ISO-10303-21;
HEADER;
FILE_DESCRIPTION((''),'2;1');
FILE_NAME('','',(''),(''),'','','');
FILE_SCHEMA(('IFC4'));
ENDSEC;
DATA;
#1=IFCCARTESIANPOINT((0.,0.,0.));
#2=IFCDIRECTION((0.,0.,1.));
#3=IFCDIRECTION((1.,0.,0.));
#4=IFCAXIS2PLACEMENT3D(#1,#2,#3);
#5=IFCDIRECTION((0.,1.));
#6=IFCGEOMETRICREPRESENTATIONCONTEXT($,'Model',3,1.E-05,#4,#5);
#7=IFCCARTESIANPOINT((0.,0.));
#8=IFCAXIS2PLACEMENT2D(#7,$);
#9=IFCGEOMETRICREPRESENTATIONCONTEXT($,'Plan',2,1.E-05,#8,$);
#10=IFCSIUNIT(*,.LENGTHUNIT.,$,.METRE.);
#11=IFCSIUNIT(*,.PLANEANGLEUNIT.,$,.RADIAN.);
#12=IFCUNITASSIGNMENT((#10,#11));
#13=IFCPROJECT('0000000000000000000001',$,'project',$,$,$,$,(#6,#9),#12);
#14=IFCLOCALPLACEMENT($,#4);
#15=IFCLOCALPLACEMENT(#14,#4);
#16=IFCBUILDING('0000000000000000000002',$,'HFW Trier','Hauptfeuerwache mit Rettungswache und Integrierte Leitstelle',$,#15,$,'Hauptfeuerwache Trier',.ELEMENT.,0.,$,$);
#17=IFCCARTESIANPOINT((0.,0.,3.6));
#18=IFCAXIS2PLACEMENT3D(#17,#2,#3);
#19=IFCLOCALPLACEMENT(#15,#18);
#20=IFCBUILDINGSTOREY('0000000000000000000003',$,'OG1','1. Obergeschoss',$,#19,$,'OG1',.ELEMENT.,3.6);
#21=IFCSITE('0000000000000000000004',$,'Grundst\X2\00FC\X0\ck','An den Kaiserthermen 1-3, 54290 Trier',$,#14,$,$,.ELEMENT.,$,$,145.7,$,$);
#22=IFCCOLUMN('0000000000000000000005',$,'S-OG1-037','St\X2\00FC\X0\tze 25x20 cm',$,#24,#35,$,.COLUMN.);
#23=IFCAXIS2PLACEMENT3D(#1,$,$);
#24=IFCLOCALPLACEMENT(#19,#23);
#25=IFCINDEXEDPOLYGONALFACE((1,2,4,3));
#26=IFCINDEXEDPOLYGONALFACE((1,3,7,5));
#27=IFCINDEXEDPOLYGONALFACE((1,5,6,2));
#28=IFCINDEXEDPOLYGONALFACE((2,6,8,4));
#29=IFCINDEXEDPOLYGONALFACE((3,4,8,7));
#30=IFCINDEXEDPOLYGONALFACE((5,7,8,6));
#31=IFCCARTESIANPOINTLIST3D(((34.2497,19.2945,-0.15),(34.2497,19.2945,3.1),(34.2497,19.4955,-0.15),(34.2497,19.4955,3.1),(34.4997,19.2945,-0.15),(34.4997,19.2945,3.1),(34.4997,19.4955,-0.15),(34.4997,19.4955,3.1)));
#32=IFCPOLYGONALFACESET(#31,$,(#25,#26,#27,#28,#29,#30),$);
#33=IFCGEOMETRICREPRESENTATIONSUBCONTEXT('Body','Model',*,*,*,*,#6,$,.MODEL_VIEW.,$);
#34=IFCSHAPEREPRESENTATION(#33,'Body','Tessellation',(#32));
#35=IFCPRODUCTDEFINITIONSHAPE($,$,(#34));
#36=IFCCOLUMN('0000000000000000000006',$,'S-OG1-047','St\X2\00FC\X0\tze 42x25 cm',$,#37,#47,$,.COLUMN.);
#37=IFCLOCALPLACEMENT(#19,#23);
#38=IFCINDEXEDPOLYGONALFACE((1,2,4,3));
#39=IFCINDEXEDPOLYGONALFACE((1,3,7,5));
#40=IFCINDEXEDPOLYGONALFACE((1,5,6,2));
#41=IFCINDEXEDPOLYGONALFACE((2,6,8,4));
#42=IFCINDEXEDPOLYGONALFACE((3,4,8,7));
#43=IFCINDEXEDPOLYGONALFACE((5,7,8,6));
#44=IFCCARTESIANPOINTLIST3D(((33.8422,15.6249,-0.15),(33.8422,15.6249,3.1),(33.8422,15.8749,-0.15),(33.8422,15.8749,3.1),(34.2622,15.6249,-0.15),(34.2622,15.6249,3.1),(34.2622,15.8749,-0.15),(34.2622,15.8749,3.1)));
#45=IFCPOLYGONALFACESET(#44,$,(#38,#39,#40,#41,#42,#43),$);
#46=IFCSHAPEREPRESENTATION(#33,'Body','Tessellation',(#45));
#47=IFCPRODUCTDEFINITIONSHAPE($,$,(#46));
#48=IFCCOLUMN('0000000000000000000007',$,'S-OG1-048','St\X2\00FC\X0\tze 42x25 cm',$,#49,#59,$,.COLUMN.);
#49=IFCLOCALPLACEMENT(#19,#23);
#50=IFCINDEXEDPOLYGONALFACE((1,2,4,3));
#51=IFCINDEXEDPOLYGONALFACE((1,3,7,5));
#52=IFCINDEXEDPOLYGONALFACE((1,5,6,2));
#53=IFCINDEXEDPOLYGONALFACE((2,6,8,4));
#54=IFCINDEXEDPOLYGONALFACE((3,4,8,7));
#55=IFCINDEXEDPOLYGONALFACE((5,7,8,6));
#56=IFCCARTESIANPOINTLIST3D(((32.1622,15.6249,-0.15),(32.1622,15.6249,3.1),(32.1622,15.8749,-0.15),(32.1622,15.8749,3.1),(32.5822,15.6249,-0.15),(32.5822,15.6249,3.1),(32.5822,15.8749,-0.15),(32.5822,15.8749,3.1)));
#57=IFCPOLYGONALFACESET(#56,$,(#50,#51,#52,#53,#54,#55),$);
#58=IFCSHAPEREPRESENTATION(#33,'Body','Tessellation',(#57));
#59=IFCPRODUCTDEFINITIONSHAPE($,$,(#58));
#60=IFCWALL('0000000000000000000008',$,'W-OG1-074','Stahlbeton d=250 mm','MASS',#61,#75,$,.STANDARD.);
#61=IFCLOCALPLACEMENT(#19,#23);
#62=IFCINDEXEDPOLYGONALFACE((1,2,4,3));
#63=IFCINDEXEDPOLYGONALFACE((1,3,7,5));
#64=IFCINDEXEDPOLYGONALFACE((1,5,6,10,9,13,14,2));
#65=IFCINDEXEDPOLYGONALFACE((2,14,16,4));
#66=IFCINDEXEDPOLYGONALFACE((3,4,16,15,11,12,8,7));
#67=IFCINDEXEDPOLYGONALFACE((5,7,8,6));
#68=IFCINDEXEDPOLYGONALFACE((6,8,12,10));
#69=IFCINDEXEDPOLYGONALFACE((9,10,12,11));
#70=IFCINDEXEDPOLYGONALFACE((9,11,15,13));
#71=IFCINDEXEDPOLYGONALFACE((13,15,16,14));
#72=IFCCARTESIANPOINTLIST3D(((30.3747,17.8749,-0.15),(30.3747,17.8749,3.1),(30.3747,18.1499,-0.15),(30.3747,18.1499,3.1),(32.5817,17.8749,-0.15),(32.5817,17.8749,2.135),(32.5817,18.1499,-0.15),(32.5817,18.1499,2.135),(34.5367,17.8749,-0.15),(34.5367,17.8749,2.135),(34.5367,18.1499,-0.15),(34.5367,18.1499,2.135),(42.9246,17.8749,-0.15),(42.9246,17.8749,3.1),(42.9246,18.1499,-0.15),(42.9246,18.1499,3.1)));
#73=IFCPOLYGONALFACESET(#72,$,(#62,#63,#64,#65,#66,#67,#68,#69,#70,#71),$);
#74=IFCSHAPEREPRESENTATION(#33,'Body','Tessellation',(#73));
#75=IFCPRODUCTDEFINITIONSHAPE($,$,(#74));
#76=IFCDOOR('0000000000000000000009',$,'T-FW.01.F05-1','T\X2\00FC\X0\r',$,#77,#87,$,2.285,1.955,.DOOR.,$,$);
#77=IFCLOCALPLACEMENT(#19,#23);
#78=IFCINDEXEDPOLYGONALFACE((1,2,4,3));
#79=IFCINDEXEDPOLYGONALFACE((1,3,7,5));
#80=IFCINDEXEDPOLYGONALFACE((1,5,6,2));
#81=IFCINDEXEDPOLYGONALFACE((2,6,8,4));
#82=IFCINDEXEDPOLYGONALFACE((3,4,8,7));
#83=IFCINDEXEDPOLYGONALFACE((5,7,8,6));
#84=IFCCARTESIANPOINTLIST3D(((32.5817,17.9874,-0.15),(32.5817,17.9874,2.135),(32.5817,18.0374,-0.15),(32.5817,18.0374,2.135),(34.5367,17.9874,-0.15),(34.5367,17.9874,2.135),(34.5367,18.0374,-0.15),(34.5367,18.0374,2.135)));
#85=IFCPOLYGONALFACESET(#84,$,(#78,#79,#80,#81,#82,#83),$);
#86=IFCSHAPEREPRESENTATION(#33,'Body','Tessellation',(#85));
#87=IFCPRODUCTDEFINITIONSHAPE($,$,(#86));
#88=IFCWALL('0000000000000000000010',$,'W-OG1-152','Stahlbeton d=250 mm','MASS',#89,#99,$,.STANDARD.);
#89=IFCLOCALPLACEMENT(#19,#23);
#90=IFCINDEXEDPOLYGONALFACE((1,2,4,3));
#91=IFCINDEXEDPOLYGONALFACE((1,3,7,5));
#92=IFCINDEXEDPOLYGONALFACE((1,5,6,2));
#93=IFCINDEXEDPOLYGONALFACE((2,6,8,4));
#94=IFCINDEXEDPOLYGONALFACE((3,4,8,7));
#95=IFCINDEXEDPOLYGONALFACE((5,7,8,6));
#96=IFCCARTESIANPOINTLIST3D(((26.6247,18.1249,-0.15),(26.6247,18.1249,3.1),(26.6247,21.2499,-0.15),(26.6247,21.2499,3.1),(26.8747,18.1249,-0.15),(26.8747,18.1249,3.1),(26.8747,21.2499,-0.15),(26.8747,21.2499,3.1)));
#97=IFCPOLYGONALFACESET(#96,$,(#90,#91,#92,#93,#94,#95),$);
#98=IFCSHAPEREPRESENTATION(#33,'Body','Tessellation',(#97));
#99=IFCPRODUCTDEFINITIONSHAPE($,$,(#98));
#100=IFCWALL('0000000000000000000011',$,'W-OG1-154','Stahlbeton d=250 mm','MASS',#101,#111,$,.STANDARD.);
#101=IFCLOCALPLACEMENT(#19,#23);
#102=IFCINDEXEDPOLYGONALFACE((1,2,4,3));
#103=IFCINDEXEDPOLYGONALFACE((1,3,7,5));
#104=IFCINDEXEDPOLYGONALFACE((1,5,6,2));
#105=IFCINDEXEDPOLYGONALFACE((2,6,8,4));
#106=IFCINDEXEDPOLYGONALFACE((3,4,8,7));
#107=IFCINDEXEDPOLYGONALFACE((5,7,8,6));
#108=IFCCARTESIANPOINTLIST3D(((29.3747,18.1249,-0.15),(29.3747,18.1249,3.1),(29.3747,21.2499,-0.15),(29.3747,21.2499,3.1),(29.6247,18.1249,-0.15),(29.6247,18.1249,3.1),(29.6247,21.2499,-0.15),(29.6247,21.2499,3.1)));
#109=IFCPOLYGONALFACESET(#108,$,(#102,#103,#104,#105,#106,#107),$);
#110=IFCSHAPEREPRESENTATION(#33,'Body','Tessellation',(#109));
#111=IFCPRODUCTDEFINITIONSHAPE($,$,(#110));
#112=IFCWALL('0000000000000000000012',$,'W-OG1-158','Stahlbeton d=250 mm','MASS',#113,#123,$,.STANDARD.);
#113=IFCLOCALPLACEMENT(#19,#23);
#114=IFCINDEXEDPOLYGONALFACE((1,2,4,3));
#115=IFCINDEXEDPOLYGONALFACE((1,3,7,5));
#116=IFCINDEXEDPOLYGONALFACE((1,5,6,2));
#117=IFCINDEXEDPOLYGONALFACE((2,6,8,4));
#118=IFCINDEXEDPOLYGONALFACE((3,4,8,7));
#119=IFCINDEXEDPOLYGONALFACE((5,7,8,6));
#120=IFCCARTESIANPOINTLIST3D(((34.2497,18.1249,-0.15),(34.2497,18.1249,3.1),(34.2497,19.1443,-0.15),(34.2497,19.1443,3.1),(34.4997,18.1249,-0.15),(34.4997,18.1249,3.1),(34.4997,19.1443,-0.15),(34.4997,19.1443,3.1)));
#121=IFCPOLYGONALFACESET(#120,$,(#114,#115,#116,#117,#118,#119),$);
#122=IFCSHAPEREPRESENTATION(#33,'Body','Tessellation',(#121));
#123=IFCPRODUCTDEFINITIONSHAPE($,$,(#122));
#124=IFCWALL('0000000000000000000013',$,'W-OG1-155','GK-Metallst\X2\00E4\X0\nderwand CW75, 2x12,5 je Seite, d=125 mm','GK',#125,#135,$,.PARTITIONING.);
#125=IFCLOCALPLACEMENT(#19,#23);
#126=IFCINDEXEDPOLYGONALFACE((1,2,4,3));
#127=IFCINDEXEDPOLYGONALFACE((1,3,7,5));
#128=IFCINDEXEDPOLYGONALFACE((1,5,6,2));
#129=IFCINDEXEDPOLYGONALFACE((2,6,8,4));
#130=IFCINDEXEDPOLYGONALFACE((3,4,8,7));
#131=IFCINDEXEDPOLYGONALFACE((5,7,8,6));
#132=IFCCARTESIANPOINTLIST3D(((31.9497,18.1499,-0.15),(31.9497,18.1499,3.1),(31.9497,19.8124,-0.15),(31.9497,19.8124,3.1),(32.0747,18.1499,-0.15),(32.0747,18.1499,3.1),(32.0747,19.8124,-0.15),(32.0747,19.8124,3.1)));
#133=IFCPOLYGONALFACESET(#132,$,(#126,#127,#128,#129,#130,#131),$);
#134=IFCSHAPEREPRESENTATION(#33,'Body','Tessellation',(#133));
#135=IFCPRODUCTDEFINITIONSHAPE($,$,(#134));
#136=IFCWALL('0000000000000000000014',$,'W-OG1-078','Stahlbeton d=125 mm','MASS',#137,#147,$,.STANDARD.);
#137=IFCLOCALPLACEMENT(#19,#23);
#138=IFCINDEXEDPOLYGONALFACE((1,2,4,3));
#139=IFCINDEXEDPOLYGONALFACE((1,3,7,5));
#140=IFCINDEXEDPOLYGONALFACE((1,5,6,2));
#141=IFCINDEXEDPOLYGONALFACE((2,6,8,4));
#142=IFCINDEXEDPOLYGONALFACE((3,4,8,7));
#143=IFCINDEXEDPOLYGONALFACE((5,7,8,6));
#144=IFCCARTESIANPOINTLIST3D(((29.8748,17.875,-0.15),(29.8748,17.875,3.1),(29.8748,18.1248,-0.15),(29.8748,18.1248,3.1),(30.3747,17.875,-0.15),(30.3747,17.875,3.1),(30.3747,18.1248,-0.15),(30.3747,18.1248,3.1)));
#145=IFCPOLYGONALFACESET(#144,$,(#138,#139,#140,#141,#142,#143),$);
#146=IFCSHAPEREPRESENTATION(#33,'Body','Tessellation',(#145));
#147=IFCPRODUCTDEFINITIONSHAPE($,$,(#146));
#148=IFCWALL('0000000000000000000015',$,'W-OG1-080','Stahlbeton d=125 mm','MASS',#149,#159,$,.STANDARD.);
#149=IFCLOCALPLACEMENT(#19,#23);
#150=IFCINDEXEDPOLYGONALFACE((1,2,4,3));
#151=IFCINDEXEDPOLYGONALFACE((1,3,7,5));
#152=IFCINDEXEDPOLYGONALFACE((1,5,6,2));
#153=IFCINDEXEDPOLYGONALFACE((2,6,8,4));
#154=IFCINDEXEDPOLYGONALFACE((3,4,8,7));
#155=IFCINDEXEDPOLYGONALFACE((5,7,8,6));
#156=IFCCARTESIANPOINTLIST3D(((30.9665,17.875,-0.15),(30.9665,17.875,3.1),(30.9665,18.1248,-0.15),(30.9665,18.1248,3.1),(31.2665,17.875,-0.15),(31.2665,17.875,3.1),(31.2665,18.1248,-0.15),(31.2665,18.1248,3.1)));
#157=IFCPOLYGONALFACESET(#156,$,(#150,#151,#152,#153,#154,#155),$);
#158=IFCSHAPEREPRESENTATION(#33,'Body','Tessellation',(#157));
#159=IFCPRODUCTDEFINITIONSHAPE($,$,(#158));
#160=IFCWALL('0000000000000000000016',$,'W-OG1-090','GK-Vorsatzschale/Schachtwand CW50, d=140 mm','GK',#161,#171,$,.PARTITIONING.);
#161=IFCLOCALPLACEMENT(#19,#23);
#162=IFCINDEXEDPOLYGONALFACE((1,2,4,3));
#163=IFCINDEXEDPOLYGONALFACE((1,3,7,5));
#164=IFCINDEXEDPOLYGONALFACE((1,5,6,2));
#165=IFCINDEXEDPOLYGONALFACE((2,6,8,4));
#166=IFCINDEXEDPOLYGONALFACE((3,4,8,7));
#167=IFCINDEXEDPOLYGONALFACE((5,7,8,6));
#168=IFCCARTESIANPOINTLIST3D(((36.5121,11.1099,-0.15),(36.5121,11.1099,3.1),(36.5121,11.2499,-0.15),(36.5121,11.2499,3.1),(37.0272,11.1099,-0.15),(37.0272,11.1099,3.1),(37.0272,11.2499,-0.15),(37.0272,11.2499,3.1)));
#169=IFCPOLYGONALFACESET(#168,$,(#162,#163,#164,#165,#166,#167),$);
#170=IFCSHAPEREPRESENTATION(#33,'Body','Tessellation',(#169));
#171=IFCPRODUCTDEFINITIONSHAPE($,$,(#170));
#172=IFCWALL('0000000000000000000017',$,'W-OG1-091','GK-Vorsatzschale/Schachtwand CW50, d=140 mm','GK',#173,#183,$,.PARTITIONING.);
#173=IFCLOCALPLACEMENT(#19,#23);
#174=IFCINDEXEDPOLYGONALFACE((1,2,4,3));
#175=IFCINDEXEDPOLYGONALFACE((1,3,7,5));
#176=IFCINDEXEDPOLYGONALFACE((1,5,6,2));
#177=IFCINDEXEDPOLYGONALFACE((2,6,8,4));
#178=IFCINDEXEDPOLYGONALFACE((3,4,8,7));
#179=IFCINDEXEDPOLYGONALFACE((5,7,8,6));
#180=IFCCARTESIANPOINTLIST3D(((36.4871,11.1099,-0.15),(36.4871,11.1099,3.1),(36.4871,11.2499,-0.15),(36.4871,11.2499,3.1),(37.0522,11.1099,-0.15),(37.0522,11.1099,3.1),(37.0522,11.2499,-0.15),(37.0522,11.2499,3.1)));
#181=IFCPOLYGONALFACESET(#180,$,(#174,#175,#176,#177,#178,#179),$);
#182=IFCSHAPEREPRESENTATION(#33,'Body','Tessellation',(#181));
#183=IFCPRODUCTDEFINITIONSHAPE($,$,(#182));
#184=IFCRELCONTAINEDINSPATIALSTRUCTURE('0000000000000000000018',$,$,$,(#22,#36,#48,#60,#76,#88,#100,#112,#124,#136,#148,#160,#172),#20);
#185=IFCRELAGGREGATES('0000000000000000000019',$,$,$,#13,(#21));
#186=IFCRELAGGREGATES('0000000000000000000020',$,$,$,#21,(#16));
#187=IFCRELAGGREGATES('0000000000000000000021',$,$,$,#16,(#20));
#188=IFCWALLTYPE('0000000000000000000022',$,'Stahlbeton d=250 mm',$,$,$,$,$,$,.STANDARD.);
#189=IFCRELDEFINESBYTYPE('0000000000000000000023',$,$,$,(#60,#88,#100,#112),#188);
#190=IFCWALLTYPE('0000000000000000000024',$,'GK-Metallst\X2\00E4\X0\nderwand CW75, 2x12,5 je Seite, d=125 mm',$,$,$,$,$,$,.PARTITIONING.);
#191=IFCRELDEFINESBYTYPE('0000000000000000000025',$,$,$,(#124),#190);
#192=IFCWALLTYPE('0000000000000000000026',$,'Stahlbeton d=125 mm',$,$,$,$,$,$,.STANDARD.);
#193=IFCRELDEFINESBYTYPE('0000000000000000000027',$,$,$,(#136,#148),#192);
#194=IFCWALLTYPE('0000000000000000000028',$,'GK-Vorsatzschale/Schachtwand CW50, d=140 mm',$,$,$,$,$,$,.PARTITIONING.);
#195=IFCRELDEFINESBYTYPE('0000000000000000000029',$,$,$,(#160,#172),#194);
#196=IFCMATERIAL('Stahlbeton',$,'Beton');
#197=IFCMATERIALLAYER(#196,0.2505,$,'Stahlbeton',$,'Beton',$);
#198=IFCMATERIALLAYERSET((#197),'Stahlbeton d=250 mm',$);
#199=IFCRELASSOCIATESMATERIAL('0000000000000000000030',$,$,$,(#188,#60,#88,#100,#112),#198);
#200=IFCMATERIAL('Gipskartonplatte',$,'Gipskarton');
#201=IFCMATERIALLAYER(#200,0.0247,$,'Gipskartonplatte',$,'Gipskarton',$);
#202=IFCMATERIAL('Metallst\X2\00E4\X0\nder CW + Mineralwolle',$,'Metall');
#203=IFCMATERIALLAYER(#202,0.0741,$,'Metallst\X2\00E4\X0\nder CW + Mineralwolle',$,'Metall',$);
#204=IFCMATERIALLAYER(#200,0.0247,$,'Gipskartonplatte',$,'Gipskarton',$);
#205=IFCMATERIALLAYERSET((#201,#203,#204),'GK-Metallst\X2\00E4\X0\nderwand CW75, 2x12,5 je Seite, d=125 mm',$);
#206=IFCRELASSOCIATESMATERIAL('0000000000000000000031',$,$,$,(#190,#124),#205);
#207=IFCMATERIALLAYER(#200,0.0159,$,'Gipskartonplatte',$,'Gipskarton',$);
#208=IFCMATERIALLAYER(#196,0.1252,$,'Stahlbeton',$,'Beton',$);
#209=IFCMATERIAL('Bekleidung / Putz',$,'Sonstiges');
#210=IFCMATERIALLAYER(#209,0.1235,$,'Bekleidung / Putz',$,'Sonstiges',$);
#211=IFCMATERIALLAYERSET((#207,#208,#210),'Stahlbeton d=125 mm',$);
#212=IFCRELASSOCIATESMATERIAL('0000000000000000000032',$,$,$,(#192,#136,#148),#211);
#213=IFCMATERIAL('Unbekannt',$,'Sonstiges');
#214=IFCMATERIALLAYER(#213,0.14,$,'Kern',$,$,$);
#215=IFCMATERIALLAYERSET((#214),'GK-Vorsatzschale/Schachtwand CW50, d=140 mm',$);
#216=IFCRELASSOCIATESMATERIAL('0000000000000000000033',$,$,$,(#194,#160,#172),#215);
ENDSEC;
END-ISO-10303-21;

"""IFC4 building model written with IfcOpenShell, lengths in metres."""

from ifc_helpers import new_model, si_unit, direction, frame, frame_2d, origin_with_axes, origin_2d, place, context, subcontext, project, spatial, rectangle, extrude, material, layer, layer_set, layer_usage, type_object, element, fill, save


model = new_model("IFC4")

# Units and contexts
model_context = context("Model", 3, precision=1e-05, world=origin_with_axes(), true_north=direction((0.0, 1.0)))
plan_context = context("Plan", 2, precision=1e-05, world=origin_2d())
body_context = subcontext(model_context, "Body", "Model", "MODEL_VIEW")
ifc_project = project(units=[si_unit("LENGTHUNIT", "METRE"), si_unit("PLANEANGLEUNIT", "RADIAN")], contexts=[model_context, plan_context])

# Site, building, storey
site_placement = place(None, origin_with_axes())
site = spatial("IfcSite", under=ifc_project, at=site_placement, Name="Grundstück", Description="An den Kaiserthermen 1-3, 54290 Trier", CompositionType="ELEMENT", RefElevation=145.7)
building_placement = place(site_placement, origin_with_axes())
building = spatial("IfcBuilding", under=site, at=building_placement, Name="HFW Trier", Description="Hauptfeuerwache mit Rettungswache und Integrierte Leitstelle", LongName="Hauptfeuerwache Trier", CompositionType="ELEMENT", ElevationOfRefHeight=0.0)
storey_placement = place(building_placement, frame((0.0, 0.0, 3.6), z_axis=(0.0, 0.0, 1.0), x_axis=(1.0, 0.0, 0.0)))
storey = spatial("IfcBuildingStorey", under=building, at=storey_placement, Name="OG1", Description="1. Obergeschoss", LongName="OG1", CompositionType="ELEMENT", Elevation=3.6)

# Columns
column_placement = place(storey_placement, frame((34.2497, 19.395, -0.15), z_axis=(0.0, 0.0, 1.0), x_axis=(1.0, 0.0, 0.0)))
element("IfcColumn", 1, at=column_placement, inside=storey, Name="S-OG1-037", Description="Stütze 25x20 cm", PredefinedType="COLUMN", context=body_context, shape_type="SweptSolid", body=[
    extrude(rectangle(XDim=0.25, YDim=0.201, at=frame_2d((0.125, 0.0))), origin_with_axes(), (0.0, 0.0, 1.0), 3.25),
])
for number, where, z_axis, x_axis, name in (
    (2, (33.8422, 15.7499, -0.15), (0.0, 0.0, 1.0), (1.0, 0.0, 0.0), "S-OG1-047"),
    (3, (32.1622, 15.7499, -0.15), (0.0, 0.0, 1.0), (1.0, 0.0, 0.0), "S-OG1-048"),
):
    element("IfcColumn", number, at=place(storey_placement, frame(where, z_axis=z_axis, x_axis=x_axis)), inside=storey, Name=name, Description="Stütze 42x25 cm", PredefinedType="COLUMN", context=body_context, shape_type="SweptSolid", body=[
        extrude(rectangle(XDim=0.42, YDim=0.25, at=frame_2d((0.21, 0.0))), origin_with_axes(), (0.0, 0.0, 1.0), 3.25),
    ])

# Wall, opening, door
ifc_material_1 = material(Name="Stahlbeton", Category="Beton")
ifc_layer_1 = layer(ifc_material_1, 0.2505, Name="Stahlbeton", Category="Beton")
ifc_layer_set_1 = layer_set([ifc_layer_1], Name="Stahlbeton d=250 mm")
ifc_layer_usage_1 = layer_usage(ifc_layer_set_1, "AXIS2", "POSITIVE", -0.1375)
wall_type_1 = type_object("IfcWallType", Name="Stahlbeton d=250 mm", PredefinedType="STANDARD", material=ifc_layer_set_1)
wall_1_placement = place(storey_placement, frame((30.3747, 18.0124, -0.15), z_axis=(0.0, 0.0, 1.0), x_axis=(1.0, 0.0, 0.0)))
wall_1 = element("IfcWall", 4, at=wall_1_placement, inside=storey, type_object=wall_type_1, material=ifc_layer_usage_1, Name="W-OG1-074", Description="Stahlbeton d=250 mm", ObjectType="MASS", PredefinedType="STANDARD", context=body_context, shape_type="SweptSolid", body=[
    extrude(rectangle(XDim=12.5499, YDim=0.275, at=frame_2d((6.2749, 0.0))), origin_with_axes(), (0.0, 0.0, 1.0), 3.25),
])
opening_1_placement = place(wall_1_placement, frame((2.207, 0.0, 0.0), z_axis=(0.0, 0.0, 1.0), x_axis=(1.0, 0.0, 0.0)))
opening_1 = element("IfcOpeningElement", 5, at=opening_1_placement, cuts=wall_1, PredefinedType="OPENING", context=body_context, shape_type="SweptSolid", body=[
    extrude(rectangle(XDim=1.955, YDim=0.375, at=frame_2d((0.9775, 0.0))), origin_with_axes(), (0.0, 0.0, 1.0), 2.285),
])
door_1_placement = place(wall_1_placement, frame((2.207, 0.0, 0.0), z_axis=(0.0, 0.0, 1.0), x_axis=(1.0, 0.0, 0.0)))
door_1 = element("IfcDoor", 6, at=door_1_placement, inside=storey, Name="T-FW.01.F05-1", Description="Tür", OverallHeight=2.285, OverallWidth=1.955, PredefinedType="DOOR", context=body_context, shape_type="SweptSolid", body=[
    extrude(rectangle(XDim=1.955, YDim=0.05, at=frame_2d((0.9775, 0.0))), origin_with_axes(), (0.0, 0.0, 1.0), 2.285),
])
fill(opening_1, door_1)

# Walls
ifc_layer_usage_2 = layer_usage(ifc_layer_set_1, "AXIS2", "POSITIVE", -0.125)
wall_2_placement = place(storey_placement, frame((26.7497, 21.2499, -0.15), z_axis=(0.0, 0.0, 1.0), x_axis=(0.0, -1.0, 0.0)))
element("IfcWall", 7, at=wall_2_placement, inside=storey, type_object=wall_type_1, material=ifc_layer_usage_2, Name="W-OG1-152", Description="Stahlbeton d=250 mm", ObjectType="MASS", PredefinedType="STANDARD", context=body_context, shape_type="SweptSolid", body=[
    extrude(rectangle(XDim=3.125, YDim=0.25, at=frame_2d((1.5625, 0.0))), origin_with_axes(), (0.0, 0.0, 1.0), 3.25),
])
ifc_layer_usage_3 = layer_usage(ifc_layer_set_1, "AXIS2", "POSITIVE", -0.125)
wall_3_placement = place(storey_placement, frame((29.4997, 21.2499, -0.15), z_axis=(0.0, 0.0, 1.0), x_axis=(0.0, -1.0, 0.0)))
element("IfcWall", 8, at=wall_3_placement, inside=storey, type_object=wall_type_1, material=ifc_layer_usage_3, Name="W-OG1-154", Description="Stahlbeton d=250 mm", ObjectType="MASS", PredefinedType="STANDARD", context=body_context, shape_type="SweptSolid", body=[
    extrude(rectangle(XDim=3.125, YDim=0.25, at=frame_2d((1.5625, 0.0))), origin_with_axes(), (0.0, 0.0, 1.0), 3.25),
])
ifc_layer_usage_4 = layer_usage(ifc_layer_set_1, "AXIS2", "POSITIVE", -0.125)
wall_4_placement = place(storey_placement, frame((34.3747, 19.1443, -0.15), z_axis=(0.0, 0.0, 1.0), x_axis=(0.0, -1.0, 0.0)))
element("IfcWall", 9, at=wall_4_placement, inside=storey, type_object=wall_type_1, material=ifc_layer_usage_4, Name="W-OG1-158", Description="Stahlbeton d=250 mm", ObjectType="MASS", PredefinedType="STANDARD", context=body_context, shape_type="SweptSolid", body=[
    extrude(rectangle(XDim=1.0194, YDim=0.25, at=frame_2d((0.5097, 0.0))), origin_with_axes(), (0.0, 0.0, 1.0), 3.25),
])
ifc_material_2 = material(Name="Gipskartonplatte", Category="Gipskarton")
ifc_layer_2 = layer(ifc_material_2, 0.0247, Name="Gipskartonplatte", Category="Gipskarton")
ifc_material_3 = material(Name="Metallständer CW + Mineralwolle", Category="Metall")
ifc_layer_3 = layer(ifc_material_3, 0.0741, Name="Metallständer CW + Mineralwolle", Category="Metall")
ifc_layer_4 = layer(ifc_material_2, 0.0247, Name="Gipskartonplatte", Category="Gipskarton")
ifc_layer_set_2 = layer_set([ifc_layer_2, ifc_layer_3, ifc_layer_4], Name="GK-Metallständerwand CW75, 2x12,5 je Seite, d=125 mm")
ifc_layer_usage_5 = layer_usage(ifc_layer_set_2, "AXIS2", "POSITIVE", -0.0625)
wall_type_2 = type_object("IfcWallType", Name="GK-Metallständerwand CW75, 2x12,5 je Seite, d=125 mm", PredefinedType="PARTITIONING", material=ifc_layer_set_2)
wall_5_placement = place(storey_placement, frame((32.0122, 19.8124, -0.15), z_axis=(0.0, 0.0, 1.0), x_axis=(0.0, -1.0, 0.0)))
element("IfcWall", 10, at=wall_5_placement, inside=storey, type_object=wall_type_2, material=ifc_layer_usage_5, Name="W-OG1-155", Description="GK-Metallständerwand CW75, 2x12,5 je Seite, d=125 mm", ObjectType="GK", PredefinedType="PARTITIONING", context=body_context, shape_type="SweptSolid", body=[
    extrude(rectangle(XDim=1.6625, YDim=0.125, at=frame_2d((0.8313, 0.0))), origin_with_axes(), (0.0, 0.0, 1.0), 3.25),
])
ifc_layer_5 = layer(ifc_material_2, 0.0159, Name="Gipskartonplatte", Category="Gipskarton")
ifc_layer_6 = layer(ifc_material_1, 0.1252, Name="Stahlbeton", Category="Beton")
ifc_material_4 = material(Name="Bekleidung / Putz", Category="Sonstiges")
ifc_layer_7 = layer(ifc_material_4, 0.1235, Name="Bekleidung / Putz", Category="Sonstiges")
ifc_layer_set_3 = layer_set([ifc_layer_5, ifc_layer_6, ifc_layer_7], Name="Stahlbeton d=125 mm")
ifc_layer_usage_6 = layer_usage(ifc_layer_set_3, "AXIS2", "POSITIVE", -0.125)
wall_type_3 = type_object("IfcWallType", Name="Stahlbeton d=125 mm", PredefinedType="STANDARD", material=ifc_layer_set_3)
wall_6_placement = place(storey_placement, frame((29.8748, 17.9999, -0.15), z_axis=(0.0, 0.0, 1.0), x_axis=(1.0, 0.0, 0.0)))
element("IfcWall", 11, at=wall_6_placement, inside=storey, type_object=wall_type_3, material=ifc_layer_usage_6, Name="W-OG1-078", Description="Stahlbeton d=125 mm", ObjectType="MASS", PredefinedType="STANDARD", context=body_context, shape_type="SweptSolid", body=[
    extrude(rectangle(XDim=0.4999, YDim=0.2499, at=frame_2d((0.25, 0.0))), origin_with_axes(), (0.0, 0.0, 1.0), 3.25),
])
ifc_layer_usage_7 = layer_usage(ifc_layer_set_3, "AXIS2", "POSITIVE", -0.125)
wall_7_placement = place(storey_placement, frame((30.9665, 17.9999, -0.15), z_axis=(0.0, 0.0, 1.0), x_axis=(1.0, 0.0, 0.0)))
element("IfcWall", 12, at=wall_7_placement, inside=storey, type_object=wall_type_3, material=ifc_layer_usage_7, Name="W-OG1-080", Description="Stahlbeton d=125 mm", ObjectType="MASS", PredefinedType="STANDARD", context=body_context, shape_type="SweptSolid", body=[
    extrude(rectangle(XDim=0.3, YDim=0.2499, at=frame_2d((0.15, 0.0))), origin_with_axes(), (0.0, 0.0, 1.0), 3.25),
])
ifc_material_5 = material(Name="Unbekannt", Category="Sonstiges")
ifc_layer_8 = layer(ifc_material_5, 0.14, Name="Kern")
ifc_layer_set_4 = layer_set([ifc_layer_8], Name="GK-Vorsatzschale/Schachtwand CW50, d=140 mm")
ifc_layer_usage_8 = layer_usage(ifc_layer_set_4, "AXIS2", "POSITIVE", -0.07)
wall_type_4 = type_object("IfcWallType", Name="GK-Vorsatzschale/Schachtwand CW50, d=140 mm", PredefinedType="PARTITIONING", material=ifc_layer_set_4)
wall_8_placement = place(storey_placement, frame((36.5121, 11.1799, -0.15), z_axis=(0.0, 0.0, 1.0), x_axis=(1.0, 0.0, 0.0)))
element("IfcWall", 13, at=wall_8_placement, inside=storey, type_object=wall_type_4, material=ifc_layer_usage_8, Name="W-OG1-090", Description="GK-Vorsatzschale/Schachtwand CW50, d=140 mm", ObjectType="GK", PredefinedType="PARTITIONING", context=body_context, shape_type="SweptSolid", body=[
    extrude(rectangle(XDim=0.5151, YDim=0.14, at=frame_2d((0.2576, 0.0))), origin_with_axes(), (0.0, 0.0, 1.0), 3.25),
])
ifc_layer_usage_9 = layer_usage(ifc_layer_set_4, "AXIS2", "POSITIVE", -0.07)
wall_9_placement = place(storey_placement, frame((36.4871, 11.1799, -0.15), z_axis=(0.0, 0.0, 1.0), x_axis=(1.0, 0.0, 0.0)))
element("IfcWall", 14, at=wall_9_placement, inside=storey, type_object=wall_type_4, material=ifc_layer_usage_9, Name="W-OG1-091", Description="GK-Vorsatzschale/Schachtwand CW50, d=140 mm", ObjectType="GK", PredefinedType="PARTITIONING", context=body_context, shape_type="SweptSolid", body=[
    extrude(rectangle(XDim=0.5651, YDim=0.14, at=frame_2d((0.2826, 0.0))), origin_with_axes(), (0.0, 0.0, 1.0), 3.25),
])

save(model, "model.ifc")
